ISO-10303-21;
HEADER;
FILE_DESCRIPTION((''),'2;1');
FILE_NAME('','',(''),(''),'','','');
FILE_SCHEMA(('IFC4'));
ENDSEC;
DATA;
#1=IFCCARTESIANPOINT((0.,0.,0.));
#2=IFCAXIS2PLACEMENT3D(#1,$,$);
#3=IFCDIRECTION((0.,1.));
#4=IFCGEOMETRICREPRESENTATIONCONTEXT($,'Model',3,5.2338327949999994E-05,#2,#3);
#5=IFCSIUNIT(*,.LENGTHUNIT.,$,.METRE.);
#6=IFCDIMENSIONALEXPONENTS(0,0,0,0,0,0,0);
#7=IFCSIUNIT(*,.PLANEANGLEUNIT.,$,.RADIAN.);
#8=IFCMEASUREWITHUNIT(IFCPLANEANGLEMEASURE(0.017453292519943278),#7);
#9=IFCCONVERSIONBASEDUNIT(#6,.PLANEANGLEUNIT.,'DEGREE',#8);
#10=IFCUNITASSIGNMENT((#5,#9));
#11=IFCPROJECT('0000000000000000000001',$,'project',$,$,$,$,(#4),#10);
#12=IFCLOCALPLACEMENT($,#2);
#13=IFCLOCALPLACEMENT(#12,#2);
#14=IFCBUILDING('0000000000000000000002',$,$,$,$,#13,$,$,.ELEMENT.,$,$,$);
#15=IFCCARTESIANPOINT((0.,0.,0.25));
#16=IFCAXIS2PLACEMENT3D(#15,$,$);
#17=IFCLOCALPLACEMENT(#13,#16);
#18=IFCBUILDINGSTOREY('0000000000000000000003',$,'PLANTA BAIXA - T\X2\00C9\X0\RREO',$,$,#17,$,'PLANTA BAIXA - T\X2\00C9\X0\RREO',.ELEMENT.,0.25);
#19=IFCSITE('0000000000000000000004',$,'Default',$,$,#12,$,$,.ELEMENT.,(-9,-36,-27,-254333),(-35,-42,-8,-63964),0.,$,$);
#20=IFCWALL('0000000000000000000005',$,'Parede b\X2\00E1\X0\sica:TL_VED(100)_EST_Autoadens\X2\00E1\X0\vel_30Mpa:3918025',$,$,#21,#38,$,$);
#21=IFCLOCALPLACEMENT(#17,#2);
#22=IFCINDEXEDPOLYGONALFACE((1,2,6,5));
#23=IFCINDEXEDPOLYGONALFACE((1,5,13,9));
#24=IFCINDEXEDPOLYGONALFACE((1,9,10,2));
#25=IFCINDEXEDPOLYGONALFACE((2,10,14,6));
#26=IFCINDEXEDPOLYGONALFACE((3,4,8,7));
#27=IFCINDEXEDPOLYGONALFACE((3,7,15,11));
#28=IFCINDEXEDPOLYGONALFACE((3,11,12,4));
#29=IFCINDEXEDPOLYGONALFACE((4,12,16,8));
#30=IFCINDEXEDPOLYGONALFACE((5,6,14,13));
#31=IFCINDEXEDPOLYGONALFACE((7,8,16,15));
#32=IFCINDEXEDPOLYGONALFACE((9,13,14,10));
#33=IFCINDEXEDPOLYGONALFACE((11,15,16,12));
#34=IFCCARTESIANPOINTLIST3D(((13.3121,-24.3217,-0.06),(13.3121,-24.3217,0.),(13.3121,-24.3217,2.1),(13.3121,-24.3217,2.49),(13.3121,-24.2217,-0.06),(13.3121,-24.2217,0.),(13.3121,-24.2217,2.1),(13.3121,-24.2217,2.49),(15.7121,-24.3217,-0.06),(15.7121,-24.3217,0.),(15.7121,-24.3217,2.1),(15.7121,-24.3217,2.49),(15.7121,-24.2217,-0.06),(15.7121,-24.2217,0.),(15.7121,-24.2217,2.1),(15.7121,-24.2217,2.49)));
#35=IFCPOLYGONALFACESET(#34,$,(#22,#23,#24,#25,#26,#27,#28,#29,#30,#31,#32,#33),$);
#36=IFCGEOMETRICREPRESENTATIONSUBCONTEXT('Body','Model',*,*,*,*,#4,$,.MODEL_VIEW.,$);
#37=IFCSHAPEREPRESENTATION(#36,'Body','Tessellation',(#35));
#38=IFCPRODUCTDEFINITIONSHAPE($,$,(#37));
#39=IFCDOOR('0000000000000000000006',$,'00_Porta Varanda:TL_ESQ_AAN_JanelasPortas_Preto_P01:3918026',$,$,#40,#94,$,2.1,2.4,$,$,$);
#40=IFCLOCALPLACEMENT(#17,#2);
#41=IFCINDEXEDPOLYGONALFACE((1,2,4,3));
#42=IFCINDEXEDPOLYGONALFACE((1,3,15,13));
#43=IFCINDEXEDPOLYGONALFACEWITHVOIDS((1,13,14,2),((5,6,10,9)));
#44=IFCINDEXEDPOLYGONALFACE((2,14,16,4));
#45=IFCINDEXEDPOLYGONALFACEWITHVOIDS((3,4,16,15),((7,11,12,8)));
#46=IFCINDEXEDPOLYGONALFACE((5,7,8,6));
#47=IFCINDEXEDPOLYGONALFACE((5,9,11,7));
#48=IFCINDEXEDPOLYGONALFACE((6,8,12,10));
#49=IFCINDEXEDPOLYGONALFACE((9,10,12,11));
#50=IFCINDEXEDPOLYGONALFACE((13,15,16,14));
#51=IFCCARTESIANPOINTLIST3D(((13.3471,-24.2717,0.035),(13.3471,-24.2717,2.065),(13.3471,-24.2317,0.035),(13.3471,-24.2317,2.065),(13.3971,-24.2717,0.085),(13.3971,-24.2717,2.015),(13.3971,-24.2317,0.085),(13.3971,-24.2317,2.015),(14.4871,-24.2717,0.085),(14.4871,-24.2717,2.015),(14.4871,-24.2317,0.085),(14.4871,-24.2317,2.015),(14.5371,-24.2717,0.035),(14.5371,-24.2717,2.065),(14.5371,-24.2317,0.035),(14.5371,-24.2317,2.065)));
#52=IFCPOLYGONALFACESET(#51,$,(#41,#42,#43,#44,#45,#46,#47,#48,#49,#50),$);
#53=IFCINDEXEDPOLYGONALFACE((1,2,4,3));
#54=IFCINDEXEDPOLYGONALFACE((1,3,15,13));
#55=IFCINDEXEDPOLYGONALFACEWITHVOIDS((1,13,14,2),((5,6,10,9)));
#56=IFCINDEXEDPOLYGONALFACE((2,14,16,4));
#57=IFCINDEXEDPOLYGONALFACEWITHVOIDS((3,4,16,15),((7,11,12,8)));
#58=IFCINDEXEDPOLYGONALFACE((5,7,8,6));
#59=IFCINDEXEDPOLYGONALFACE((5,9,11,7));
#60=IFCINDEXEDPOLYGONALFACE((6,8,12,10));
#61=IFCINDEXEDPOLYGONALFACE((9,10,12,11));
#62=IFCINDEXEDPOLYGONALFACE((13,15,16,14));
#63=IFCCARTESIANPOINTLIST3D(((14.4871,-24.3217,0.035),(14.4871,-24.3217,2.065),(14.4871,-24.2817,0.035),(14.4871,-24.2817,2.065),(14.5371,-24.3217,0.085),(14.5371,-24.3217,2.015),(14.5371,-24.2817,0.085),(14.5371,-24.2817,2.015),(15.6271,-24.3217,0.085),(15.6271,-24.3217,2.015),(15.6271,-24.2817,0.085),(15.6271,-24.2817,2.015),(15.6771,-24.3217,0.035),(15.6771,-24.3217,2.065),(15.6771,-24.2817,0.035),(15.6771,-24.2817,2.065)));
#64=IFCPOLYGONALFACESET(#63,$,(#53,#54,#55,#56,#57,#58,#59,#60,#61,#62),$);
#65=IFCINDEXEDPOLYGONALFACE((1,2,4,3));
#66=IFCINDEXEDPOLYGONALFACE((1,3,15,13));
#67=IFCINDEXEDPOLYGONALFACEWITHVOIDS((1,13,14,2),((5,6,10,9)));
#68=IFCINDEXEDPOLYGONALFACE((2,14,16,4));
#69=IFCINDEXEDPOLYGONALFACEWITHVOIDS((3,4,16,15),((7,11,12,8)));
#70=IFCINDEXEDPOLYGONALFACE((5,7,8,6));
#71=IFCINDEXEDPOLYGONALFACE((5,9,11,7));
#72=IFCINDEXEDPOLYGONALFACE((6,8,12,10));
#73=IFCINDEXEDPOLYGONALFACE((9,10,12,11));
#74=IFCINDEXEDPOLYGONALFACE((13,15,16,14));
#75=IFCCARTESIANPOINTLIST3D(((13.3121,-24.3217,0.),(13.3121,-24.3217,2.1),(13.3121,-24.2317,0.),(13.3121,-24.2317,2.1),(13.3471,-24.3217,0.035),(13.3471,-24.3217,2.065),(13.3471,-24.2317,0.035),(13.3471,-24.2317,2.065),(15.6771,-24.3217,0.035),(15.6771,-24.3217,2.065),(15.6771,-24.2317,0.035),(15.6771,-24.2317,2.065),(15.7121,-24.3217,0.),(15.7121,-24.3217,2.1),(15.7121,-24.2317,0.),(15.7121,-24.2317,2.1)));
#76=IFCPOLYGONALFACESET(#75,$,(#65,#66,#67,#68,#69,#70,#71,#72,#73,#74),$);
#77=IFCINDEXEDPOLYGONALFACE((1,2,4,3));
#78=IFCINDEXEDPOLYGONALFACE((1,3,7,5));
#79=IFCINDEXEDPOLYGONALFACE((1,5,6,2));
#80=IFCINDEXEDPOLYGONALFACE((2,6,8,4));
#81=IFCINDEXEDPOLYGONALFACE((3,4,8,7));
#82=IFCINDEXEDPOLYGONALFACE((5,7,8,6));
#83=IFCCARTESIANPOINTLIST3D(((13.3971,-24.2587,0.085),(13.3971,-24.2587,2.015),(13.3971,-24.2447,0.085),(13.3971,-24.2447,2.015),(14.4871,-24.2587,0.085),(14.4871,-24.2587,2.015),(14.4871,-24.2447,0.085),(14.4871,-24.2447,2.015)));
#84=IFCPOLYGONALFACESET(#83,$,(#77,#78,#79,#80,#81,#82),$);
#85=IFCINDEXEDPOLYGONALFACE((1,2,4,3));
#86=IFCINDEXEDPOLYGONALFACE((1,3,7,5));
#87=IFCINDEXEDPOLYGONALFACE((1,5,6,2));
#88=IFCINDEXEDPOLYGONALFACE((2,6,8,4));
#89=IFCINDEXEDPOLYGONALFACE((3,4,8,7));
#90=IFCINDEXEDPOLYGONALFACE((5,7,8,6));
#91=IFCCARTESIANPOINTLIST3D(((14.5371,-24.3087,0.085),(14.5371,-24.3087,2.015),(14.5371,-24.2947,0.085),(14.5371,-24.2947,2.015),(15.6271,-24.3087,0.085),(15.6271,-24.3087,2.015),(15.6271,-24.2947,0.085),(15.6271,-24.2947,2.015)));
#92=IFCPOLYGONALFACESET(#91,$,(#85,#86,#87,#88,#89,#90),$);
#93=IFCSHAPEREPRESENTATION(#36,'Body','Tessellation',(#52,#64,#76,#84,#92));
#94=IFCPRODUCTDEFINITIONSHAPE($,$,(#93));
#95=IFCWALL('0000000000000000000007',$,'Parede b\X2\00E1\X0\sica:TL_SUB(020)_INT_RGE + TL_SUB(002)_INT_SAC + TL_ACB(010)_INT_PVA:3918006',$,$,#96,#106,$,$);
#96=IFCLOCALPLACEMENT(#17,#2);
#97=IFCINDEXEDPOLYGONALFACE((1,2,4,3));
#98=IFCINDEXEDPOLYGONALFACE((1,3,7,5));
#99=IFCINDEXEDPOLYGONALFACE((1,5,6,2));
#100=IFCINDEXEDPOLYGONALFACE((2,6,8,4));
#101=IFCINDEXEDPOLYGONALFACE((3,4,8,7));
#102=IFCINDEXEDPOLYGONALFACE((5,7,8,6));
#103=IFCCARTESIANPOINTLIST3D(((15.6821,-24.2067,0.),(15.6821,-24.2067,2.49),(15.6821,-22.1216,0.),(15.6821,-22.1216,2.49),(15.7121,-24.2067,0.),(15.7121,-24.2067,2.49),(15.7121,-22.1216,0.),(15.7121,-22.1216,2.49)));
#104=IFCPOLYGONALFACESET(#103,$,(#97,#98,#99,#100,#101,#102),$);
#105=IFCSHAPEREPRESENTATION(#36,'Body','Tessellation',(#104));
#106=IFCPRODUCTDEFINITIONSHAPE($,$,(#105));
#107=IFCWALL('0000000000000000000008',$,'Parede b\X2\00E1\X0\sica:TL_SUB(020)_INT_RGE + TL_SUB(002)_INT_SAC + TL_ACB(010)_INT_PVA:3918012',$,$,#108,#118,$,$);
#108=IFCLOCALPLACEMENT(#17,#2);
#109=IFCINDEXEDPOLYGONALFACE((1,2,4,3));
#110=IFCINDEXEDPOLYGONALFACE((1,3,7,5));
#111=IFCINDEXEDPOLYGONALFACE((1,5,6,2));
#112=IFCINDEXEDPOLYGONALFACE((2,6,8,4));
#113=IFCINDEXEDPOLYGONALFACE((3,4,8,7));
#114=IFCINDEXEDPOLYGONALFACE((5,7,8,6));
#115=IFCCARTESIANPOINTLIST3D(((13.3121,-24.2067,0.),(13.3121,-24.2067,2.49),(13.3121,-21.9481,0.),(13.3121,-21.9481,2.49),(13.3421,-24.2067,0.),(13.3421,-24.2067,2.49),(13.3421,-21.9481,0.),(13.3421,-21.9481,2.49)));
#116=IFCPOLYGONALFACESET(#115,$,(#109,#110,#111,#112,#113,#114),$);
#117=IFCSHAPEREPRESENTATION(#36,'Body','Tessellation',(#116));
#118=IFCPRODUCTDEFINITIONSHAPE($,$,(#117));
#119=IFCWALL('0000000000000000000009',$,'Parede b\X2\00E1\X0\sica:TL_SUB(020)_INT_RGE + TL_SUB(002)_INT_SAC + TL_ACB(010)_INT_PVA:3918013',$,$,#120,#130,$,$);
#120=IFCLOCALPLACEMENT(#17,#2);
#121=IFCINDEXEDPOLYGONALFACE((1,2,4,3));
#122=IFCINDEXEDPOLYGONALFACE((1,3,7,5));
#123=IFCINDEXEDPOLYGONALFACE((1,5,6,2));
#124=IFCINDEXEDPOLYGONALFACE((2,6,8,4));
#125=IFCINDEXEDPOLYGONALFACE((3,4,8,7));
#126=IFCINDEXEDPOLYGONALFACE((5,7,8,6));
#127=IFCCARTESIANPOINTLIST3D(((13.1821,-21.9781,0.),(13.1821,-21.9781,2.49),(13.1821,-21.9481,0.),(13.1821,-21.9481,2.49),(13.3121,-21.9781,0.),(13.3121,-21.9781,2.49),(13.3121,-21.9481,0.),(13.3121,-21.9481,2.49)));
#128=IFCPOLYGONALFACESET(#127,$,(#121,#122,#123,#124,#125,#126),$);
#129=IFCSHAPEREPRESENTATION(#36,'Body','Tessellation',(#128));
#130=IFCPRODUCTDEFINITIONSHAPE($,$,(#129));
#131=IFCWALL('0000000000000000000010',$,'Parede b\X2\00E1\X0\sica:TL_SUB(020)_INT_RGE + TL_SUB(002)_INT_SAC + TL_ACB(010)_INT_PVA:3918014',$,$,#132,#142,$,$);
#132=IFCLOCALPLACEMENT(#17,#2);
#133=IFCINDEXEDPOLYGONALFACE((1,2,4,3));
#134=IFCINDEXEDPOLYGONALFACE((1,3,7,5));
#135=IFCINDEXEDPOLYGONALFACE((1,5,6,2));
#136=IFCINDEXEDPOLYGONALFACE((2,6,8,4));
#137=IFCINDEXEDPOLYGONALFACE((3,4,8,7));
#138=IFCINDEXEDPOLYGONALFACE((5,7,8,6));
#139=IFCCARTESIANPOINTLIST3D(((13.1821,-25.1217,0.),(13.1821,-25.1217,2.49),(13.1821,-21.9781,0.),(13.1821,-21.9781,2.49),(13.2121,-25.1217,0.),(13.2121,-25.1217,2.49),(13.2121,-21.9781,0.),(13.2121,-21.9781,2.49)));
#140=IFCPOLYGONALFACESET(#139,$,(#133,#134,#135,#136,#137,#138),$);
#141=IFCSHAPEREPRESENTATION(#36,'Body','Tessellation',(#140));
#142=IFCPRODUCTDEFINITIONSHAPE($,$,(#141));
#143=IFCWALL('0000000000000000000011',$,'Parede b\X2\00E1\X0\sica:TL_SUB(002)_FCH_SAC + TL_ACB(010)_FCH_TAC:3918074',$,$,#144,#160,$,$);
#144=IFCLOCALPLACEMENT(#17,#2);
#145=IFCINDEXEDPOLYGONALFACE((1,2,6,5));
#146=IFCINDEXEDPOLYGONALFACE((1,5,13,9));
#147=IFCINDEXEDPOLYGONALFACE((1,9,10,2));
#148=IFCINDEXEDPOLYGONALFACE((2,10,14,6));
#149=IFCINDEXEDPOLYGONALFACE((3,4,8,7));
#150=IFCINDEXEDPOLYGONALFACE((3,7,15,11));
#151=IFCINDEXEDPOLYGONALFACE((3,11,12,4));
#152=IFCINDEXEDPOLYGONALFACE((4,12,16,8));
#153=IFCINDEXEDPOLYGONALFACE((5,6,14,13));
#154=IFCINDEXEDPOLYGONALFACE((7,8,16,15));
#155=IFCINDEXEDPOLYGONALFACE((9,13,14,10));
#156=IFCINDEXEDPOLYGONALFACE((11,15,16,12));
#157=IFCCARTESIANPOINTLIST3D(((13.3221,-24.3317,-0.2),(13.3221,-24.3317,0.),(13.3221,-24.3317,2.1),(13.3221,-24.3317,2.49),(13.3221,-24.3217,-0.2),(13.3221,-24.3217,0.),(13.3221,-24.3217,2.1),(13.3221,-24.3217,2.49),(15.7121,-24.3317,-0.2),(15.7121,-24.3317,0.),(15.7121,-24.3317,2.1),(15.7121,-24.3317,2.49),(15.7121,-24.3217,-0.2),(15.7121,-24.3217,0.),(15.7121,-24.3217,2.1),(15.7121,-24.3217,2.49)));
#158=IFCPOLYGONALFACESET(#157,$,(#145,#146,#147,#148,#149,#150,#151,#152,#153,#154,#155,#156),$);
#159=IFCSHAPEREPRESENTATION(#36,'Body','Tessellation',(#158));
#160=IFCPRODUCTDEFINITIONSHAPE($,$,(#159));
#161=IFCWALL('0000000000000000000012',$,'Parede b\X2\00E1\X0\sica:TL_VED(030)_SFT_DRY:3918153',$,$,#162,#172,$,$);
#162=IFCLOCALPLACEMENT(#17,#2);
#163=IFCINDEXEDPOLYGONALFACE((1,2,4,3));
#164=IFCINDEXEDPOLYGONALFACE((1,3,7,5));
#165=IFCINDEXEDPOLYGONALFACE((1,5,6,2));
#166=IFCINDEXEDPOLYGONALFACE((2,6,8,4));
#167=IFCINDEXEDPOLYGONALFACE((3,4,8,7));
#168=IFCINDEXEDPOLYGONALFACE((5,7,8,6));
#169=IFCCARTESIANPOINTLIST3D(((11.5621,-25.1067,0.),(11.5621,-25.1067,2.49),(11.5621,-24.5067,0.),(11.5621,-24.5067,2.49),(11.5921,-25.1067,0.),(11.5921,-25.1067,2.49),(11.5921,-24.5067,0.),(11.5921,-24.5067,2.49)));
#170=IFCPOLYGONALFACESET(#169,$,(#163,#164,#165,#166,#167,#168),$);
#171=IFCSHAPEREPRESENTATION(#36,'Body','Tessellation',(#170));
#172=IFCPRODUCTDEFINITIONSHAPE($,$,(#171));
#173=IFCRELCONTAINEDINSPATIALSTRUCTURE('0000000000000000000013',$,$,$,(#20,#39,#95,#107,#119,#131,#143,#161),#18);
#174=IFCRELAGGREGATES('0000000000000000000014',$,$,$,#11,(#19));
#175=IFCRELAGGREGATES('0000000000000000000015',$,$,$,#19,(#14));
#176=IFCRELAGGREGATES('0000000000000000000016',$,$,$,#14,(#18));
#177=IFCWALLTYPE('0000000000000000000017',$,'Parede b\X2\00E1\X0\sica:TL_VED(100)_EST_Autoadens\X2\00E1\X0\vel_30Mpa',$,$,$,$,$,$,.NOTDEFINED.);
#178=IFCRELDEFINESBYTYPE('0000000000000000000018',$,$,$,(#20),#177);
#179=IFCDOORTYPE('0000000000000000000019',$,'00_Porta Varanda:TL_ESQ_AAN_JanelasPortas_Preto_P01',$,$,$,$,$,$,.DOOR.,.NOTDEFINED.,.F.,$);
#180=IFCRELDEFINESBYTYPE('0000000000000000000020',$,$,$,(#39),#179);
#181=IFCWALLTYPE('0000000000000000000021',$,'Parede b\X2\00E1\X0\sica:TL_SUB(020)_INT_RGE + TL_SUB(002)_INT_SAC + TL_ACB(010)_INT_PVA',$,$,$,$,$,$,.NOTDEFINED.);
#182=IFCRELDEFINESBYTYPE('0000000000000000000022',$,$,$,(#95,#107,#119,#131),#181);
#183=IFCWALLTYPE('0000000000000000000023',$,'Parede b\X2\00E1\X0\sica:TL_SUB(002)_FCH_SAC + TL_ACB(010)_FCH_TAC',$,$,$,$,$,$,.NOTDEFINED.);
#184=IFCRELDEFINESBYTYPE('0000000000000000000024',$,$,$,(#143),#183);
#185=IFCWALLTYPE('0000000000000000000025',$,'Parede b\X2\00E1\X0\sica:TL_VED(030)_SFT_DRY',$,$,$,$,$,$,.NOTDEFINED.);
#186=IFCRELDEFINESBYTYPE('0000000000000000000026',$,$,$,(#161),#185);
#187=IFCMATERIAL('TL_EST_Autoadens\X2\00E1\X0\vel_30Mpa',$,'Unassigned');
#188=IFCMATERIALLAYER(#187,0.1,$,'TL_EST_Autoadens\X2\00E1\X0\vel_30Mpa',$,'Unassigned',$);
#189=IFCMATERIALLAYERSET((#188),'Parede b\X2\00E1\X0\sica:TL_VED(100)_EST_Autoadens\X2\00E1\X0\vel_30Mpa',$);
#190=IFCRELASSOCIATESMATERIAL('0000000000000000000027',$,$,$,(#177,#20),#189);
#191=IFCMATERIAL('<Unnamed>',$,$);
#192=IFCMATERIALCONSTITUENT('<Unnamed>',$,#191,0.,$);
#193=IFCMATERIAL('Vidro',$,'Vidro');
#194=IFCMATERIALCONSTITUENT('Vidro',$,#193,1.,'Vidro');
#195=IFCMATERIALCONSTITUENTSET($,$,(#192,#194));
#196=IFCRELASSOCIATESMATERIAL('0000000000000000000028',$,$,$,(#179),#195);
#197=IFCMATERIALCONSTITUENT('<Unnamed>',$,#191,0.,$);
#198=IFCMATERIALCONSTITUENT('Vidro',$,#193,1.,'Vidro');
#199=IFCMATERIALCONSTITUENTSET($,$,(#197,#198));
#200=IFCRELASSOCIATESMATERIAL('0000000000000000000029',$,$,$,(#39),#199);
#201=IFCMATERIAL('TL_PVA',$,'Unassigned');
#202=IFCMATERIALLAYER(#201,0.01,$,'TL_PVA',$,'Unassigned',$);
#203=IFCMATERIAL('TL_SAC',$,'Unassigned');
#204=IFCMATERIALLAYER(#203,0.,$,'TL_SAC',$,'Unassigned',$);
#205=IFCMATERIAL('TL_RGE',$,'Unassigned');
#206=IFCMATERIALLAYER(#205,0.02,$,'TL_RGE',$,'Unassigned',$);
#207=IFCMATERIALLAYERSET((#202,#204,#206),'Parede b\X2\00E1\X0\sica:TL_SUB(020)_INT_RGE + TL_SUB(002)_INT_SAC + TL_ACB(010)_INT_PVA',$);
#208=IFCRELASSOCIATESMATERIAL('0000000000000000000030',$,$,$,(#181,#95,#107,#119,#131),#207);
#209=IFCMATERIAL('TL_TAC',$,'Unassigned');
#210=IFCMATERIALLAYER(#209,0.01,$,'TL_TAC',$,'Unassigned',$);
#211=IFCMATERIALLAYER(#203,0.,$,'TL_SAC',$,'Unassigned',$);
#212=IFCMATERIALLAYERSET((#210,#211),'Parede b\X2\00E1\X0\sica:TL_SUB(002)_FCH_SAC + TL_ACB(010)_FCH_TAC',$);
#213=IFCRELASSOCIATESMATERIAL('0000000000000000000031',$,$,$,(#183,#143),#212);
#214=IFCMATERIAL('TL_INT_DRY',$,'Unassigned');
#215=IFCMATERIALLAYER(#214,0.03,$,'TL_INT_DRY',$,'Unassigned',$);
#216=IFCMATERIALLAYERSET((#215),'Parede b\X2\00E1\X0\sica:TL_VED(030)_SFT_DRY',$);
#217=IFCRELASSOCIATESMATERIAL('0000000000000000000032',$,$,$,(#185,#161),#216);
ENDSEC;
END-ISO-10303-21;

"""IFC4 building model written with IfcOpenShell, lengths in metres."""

from ifc_helpers import new_model, entity, si_unit, converted_unit, direction, frame, frame_2d, origin, place, context, subcontext, project, spatial, polyline, rectangle, outline, extrude, source, transform, mapped, material, layer, layer_set, layer_usage, constituent, constituent_set, type_object, type_shapes, element, fill, save


model = new_model("IFC4")

# Units and contexts
model_context = context("Model", 3, precision=5.2338327949999994e-05, world=origin(), true_north=direction((0.0, 1.0)))
body_context = subcontext(model_context, "Body", "Model", "MODEL_VIEW")
ifc_project = project(units=[si_unit("LENGTHUNIT", "METRE"), converted_unit("PLANEANGLEUNIT", "DEGREE", entity("IfcPlaneAngleMeasure", 0.017453292519943278), si_unit("PLANEANGLEUNIT", "RADIAN"), dimensions=[0, 0, 0, 0, 0, 0, 0])], contexts=[model_context])

# Site, building, storey
site_placement = place(None, frame((0.0, 0.0, 0.0)))
site = spatial("IfcSite", under=ifc_project, at=site_placement, Name="Default", CompositionType="ELEMENT", RefLatitude=(-9, -36, -27, -254333), RefLongitude=(-35, -42, -8, -63964), RefElevation=0.0)
building_placement = place(site_placement, origin())
building = spatial("IfcBuilding", under=site, at=building_placement, CompositionType="ELEMENT")
storey_placement = place(building_placement, frame((0.0, 0.0, 0.25)))
storey = spatial("IfcBuildingStorey", under=building, at=storey_placement, Name="PLANTA BAIXA - TÉRREO", LongName="PLANTA BAIXA - TÉRREO", CompositionType="ELEMENT", Elevation=0.25)

# Shared definitions
ifc_material_1 = material(Name="TL_EST_Autoadensável_30Mpa", Category="Unassigned")
ifc_layer_1 = layer(ifc_material_1, 0.1, Name="TL_EST_Autoadensável_30Mpa", Category="Unassigned")
ifc_layer_set_1 = layer_set([ifc_layer_1], Name="Parede básica:TL_VED(100)_EST_Autoadensável_30Mpa")
wall_type_1 = type_object("IfcWallType", Name="Parede básica:TL_VED(100)_EST_Autoadensável_30Mpa", PredefinedType="NOTDEFINED", material=ifc_layer_set_1)

# Shared definitions
ifc_material_2 = material(Name="Vidro", Category="Vidro")

# Wall, opening, door
ifc_layer_usage_1 = layer_usage(ifc_layer_set_1, "AXIS2", "NEGATIVE", 0.05)
wall_1_placement = place(storey_placement, frame((15.7121, -24.2717, -0.06), z_axis=(0.0, 0.0, 1.0), x_axis=(-1.0, 0.0, 0.0)))
wall_1 = element("IfcWall", 1, at=wall_1_placement, inside=storey, type_object=wall_type_1, material=ifc_layer_usage_1, Name="Parede básica:TL_VED(100)_EST_Autoadensável_30Mpa:3918025", context=body_context, shape_type="SweptSolid", body=[
    extrude(rectangle(XDim=2.4, YDim=0.1, at=frame_2d((1.2, 0.0), x_axis=(-1.0, 0.0))), origin(), (0.0, 0.0, 1.0), 2.55),
])
opening_1_placement = place(wall_1_placement, frame((2.4, 0.05, 0.06)))
opening_1 = element("IfcOpeningElement", 2, at=opening_1_placement, cuts=wall_1, PredefinedType="OPENING", context=body_context, shape_type="SweptSolid", body=[
    extrude(rectangle(XDim=2.1, YDim=2.4, at=frame_2d((1.05, 1.2), x_axis=(1.0, 0.0))), frame((0.0, 0.0, 0.0), z_axis=(0.0, -1.0, 0.0), x_axis=(0.0, 0.0, 1.0)), (0.0, 0.0, 1.0), 0.1),
])
ifc_material_3 = material(Name="<Unnamed>")
ifc_constituent_1 = constituent(ifc_material_3, Name="<Unnamed>", fraction=0.0)
ifc_constituent_2 = constituent(ifc_material_2, Name="Vidro", Category="Vidro", fraction=1.0)
ifc_constituent_set_1 = constituent_set(constituents=[ifc_constituent_1, ifc_constituent_2])
ifc_constituent_3 = constituent(ifc_material_3, Name="<Unnamed>", fraction=0.0)
ifc_constituent_4 = constituent(ifc_material_2, Name="Vidro", Category="Vidro", fraction=1.0)
ifc_constituent_set_2 = constituent_set(constituents=[ifc_constituent_3, ifc_constituent_4])
door_type = type_object("IfcDoorType", Name="00_Porta Varanda:TL_ESQ_AAN_JanelasPortas_Preto_P01", OperationType="NOTDEFINED", ParameterTakesPrecedence=False, PredefinedType="DOOR", material=ifc_constituent_set_2)
shared_shape_1 = source(origin(), body_context, "Body", "SweptSolid", [
    extrude(outline(polyline([(-0.595, -1.015), (0.595, -1.015), (0.595, 1.015), (-0.595, 1.015), (-0.595, -1.015)]), holes=[polyline([(-0.545, 0.965), (0.545, 0.965), (0.545, -0.965), (-0.545, -0.965), (-0.545, 0.965)])]), frame((0.63, 0.09, 1.05), z_axis=(0.0, -1.0, 0.0), x_axis=(-1.0, 0.0, 0.0)), (0.0, 0.0, 1.0), 0.04),
    extrude(outline(polyline([(-0.595, -1.015), (0.595, -1.015), (0.595, 1.015), (-0.595, 1.015), (-0.595, -1.015)]), holes=[polyline([(-0.545, 0.965), (0.545, 0.965), (0.545, -0.965), (-0.545, -0.965), (-0.545, 0.965)])]), frame((1.77, 0.04, 1.05), z_axis=(0.0, -1.0, 0.0), x_axis=(1.0, 0.0, 0.0)), (0.0, 0.0, 1.0), 0.04),
    extrude(outline(polyline([(-1.2, -1.05), (1.2, -1.05), (1.2, 1.05), (-1.2, 1.05), (-1.2, -1.05)]), holes=[polyline([(-1.165, 1.015), (1.165, 1.015), (1.165, -1.015), (-1.165, -1.015), (-1.165, 1.015)])]), frame((1.2, 0.09, 1.05), z_axis=(0.0, -1.0, 0.0), x_axis=(1.0, 0.0, 0.0)), (0.0, 0.0, 1.0), 0.09),
    extrude(rectangle(XDim=1.09, YDim=0.014, at=frame_2d((0.0, 0.0), x_axis=(1.0, 0.0))), frame((0.63, 0.07, 0.085), z_axis=(0.0, 0.0, 1.0), x_axis=(-1.0, 0.0, 0.0)), (0.0, 0.0, 1.0), 1.93),
    extrude(rectangle(XDim=1.09, YDim=0.014, at=frame_2d((0.0, 0.0), x_axis=(1.0, 0.0))), frame((1.77, 0.02, 0.085), z_axis=(0.0, 0.0, 1.0), x_axis=(-1.0, 0.0, 0.0)), (0.0, 0.0, 1.0), 1.93),
])
type_shapes(door_type, [shared_shape_1])
door_placement = place(opening_1_placement, frame((0.0, 0.0, 0.0), z_axis=(0.0, 0.0, 1.0), x_axis=(-1.0, 0.0, 0.0)))
door = element("IfcDoor", 3, at=door_placement, inside=storey, type_object=door_type, material=ifc_constituent_set_1, Name="00_Porta Varanda:TL_ESQ_AAN_JanelasPortas_Preto_P01:3918026", OverallHeight=2.1, OverallWidth=2.4, context=body_context, shape_type="MappedRepresentation", body=[
    mapped(shared_shape_1, transform((0.0, 0.0, 0.0), scale=1.0)),
])
fill(opening_1, door)

# Walls
ifc_material_4 = material(Name="TL_PVA", Category="Unassigned")
ifc_layer_2 = layer(ifc_material_4, 0.01, Name="TL_PVA", Category="Unassigned")
ifc_material_5 = material(Name="TL_SAC", Category="Unassigned")
ifc_layer_3 = layer(ifc_material_5, 0.0, Name="TL_SAC", Category="Unassigned")
ifc_material_6 = material(Name="TL_RGE", Category="Unassigned")
ifc_layer_4 = layer(ifc_material_6, 0.02, Name="TL_RGE", Category="Unassigned")
ifc_layer_set_2 = layer_set([ifc_layer_2, ifc_layer_3, ifc_layer_4], Name="Parede básica:TL_SUB(020)_INT_RGE + TL_SUB(002)_INT_SAC + TL_ACB(010)_INT_PVA")
ifc_layer_usage_2 = layer_usage(ifc_layer_set_2, "AXIS2", "NEGATIVE", 0.015)
wall_type_2 = type_object("IfcWallType", Name="Parede básica:TL_SUB(020)_INT_RGE + TL_SUB(002)_INT_SAC + TL_ACB(010)_INT_PVA", PredefinedType="NOTDEFINED", material=ifc_layer_set_2)
wall_2_placement = place(storey_placement, frame((15.6971, -24.2067, 0.0), z_axis=(0.0, 0.0, 1.0), x_axis=(0.0, 1.0, 0.0)))
element("IfcWall", 4, at=wall_2_placement, inside=storey, type_object=wall_type_2, material=ifc_layer_usage_2, Name="Parede básica:TL_SUB(020)_INT_RGE + TL_SUB(002)_INT_SAC + TL_ACB(010)_INT_PVA:3918006", context=body_context, shape_type="SweptSolid", body=[
    extrude(rectangle(XDim=2.0851, YDim=0.03, at=frame_2d((1.0426, 0.0), x_axis=(-1.0, 0.0))), origin(), (0.0, 0.0, 1.0), 2.49),
])
ifc_layer_usage_3 = layer_usage(ifc_layer_set_2, "AXIS2", "NEGATIVE", 0.015)
wall_3_placement = place(storey_placement, frame((13.3271, -21.9481, 0.0), z_axis=(0.0, 0.0, 1.0), x_axis=(0.0, -1.0, 0.0)))
element("IfcWall", 5, at=wall_3_placement, inside=storey, type_object=wall_type_2, material=ifc_layer_usage_3, Name="Parede básica:TL_SUB(020)_INT_RGE + TL_SUB(002)_INT_SAC + TL_ACB(010)_INT_PVA:3918012", context=body_context, shape_type="SweptSolid", body=[
    extrude(rectangle(XDim=2.2587, YDim=0.03, at=frame_2d((1.1293, 0.0), x_axis=(-1.0, 0.0))), origin(), (0.0, 0.0, 1.0), 2.49),
])
ifc_layer_usage_4 = layer_usage(ifc_layer_set_2, "AXIS2", "NEGATIVE", 0.015)
wall_4_placement = place(storey_placement, frame((13.1821, -21.9631, 0.0)))
element("IfcWall", 6, at=wall_4_placement, inside=storey, type_object=wall_type_2, material=ifc_layer_usage_4, Name="Parede básica:TL_SUB(020)_INT_RGE + TL_SUB(002)_INT_SAC + TL_ACB(010)_INT_PVA:3918013", context=body_context, shape_type="SweptSolid", body=[
    extrude(rectangle(XDim=0.13, YDim=0.03, at=frame_2d((0.065, 0.0), x_axis=(-1.0, 0.0))), origin(), (0.0, 0.0, 1.0), 2.49),
])
ifc_layer_usage_5 = layer_usage(ifc_layer_set_2, "AXIS2", "NEGATIVE", 0.015)
wall_5_placement = place(storey_placement, frame((13.1971, -25.1217, 0.0), z_axis=(0.0, 0.0, 1.0), x_axis=(0.0, 1.0, 0.0)))
element("IfcWall", 7, at=wall_5_placement, inside=storey, type_object=wall_type_2, material=ifc_layer_usage_5, Name="Parede básica:TL_SUB(020)_INT_RGE + TL_SUB(002)_INT_SAC + TL_ACB(010)_INT_PVA:3918014", context=body_context, shape_type="SweptSolid", body=[
    extrude(rectangle(XDim=3.1437, YDim=0.03, at=frame_2d((1.5718, 0.0), x_axis=(-1.0, 0.0))), origin(), (0.0, 0.0, 1.0), 2.49),
])

# Wall, opening
ifc_material_7 = material(Name="TL_TAC", Category="Unassigned")
ifc_layer_5 = layer(ifc_material_7, 0.01, Name="TL_TAC", Category="Unassigned")
ifc_layer_6 = layer(ifc_material_5, 0.0, Name="TL_SAC", Category="Unassigned")
ifc_layer_set_3 = layer_set([ifc_layer_5, ifc_layer_6], Name="Parede básica:TL_SUB(002)_FCH_SAC + TL_ACB(010)_FCH_TAC")
wall_type_3 = type_object("IfcWallType", Name="Parede básica:TL_SUB(002)_FCH_SAC + TL_ACB(010)_FCH_TAC", PredefinedType="NOTDEFINED", material=ifc_layer_set_3)
ifc_layer_usage_6 = layer_usage(ifc_layer_set_3, "AXIS2", "POSITIVE", -0.005)
wall_6_placement = place(storey_placement, frame((13.3221, -24.3267, -0.2)))
wall_6 = element("IfcWall", 8, at=wall_6_placement, inside=storey, type_object=wall_type_3, material=ifc_layer_usage_6, Name="Parede básica:TL_SUB(002)_FCH_SAC + TL_ACB(010)_FCH_TAC:3918074", context=body_context, shape_type="SweptSolid", body=[
    extrude(rectangle(XDim=2.39, YDim=0.01, at=frame_2d((1.195, 0.0), x_axis=(-1.0, 0.0))), origin(), (0.0, 0.0, 1.0), 2.69),
])
opening_2_placement = place(wall_6_placement, frame((-13.3221, 24.3267, 0.2)))
element("IfcOpeningElement", 9, at=opening_2_placement, cuts=wall_6, PredefinedType="OPENING", context=body_context, shape_type="SweptSolid", body=[
    extrude(rectangle(XDim=2.1, YDim=2.4, at=frame_2d((0.0, 0.0), x_axis=(0.0, 1.0))), frame((14.5121, -25.8457, 1.05), z_axis=(0.0, 1.0, 0.0), x_axis=(-1.0, 0.0, 0.0)), (0.0, 0.0, 1.0), 3.048),
])

# Wall
ifc_material_8 = material(Name="TL_INT_DRY", Category="Unassigned")
ifc_layer_7 = layer(ifc_material_8, 0.03, Name="TL_INT_DRY", Category="Unassigned")
ifc_layer_set_4 = layer_set([ifc_layer_7], Name="Parede básica:TL_VED(030)_SFT_DRY")
ifc_layer_usage_7 = layer_usage(ifc_layer_set_4, "AXIS2", "POSITIVE", -0.015)
wall_type_4 = type_object("IfcWallType", Name="Parede básica:TL_VED(030)_SFT_DRY", PredefinedType="NOTDEFINED", material=ifc_layer_set_4)
wall_7_placement = place(storey_placement, frame((11.5771, -25.1067, 0.0), z_axis=(0.0, 0.0, 1.0), x_axis=(0.0, 1.0, 0.0)))
element("IfcWall", 10, at=wall_7_placement, inside=storey, type_object=wall_type_4, material=ifc_layer_usage_7, Name="Parede básica:TL_VED(030)_SFT_DRY:3918153", context=body_context, shape_type="SweptSolid", body=[
    extrude(rectangle(XDim=0.6, YDim=0.03, at=frame_2d((0.3, 0.0), x_axis=(-1.0, 0.0))), origin(), (0.0, 0.0, 1.0), 2.49),
])

save(model, "model.ifc")
